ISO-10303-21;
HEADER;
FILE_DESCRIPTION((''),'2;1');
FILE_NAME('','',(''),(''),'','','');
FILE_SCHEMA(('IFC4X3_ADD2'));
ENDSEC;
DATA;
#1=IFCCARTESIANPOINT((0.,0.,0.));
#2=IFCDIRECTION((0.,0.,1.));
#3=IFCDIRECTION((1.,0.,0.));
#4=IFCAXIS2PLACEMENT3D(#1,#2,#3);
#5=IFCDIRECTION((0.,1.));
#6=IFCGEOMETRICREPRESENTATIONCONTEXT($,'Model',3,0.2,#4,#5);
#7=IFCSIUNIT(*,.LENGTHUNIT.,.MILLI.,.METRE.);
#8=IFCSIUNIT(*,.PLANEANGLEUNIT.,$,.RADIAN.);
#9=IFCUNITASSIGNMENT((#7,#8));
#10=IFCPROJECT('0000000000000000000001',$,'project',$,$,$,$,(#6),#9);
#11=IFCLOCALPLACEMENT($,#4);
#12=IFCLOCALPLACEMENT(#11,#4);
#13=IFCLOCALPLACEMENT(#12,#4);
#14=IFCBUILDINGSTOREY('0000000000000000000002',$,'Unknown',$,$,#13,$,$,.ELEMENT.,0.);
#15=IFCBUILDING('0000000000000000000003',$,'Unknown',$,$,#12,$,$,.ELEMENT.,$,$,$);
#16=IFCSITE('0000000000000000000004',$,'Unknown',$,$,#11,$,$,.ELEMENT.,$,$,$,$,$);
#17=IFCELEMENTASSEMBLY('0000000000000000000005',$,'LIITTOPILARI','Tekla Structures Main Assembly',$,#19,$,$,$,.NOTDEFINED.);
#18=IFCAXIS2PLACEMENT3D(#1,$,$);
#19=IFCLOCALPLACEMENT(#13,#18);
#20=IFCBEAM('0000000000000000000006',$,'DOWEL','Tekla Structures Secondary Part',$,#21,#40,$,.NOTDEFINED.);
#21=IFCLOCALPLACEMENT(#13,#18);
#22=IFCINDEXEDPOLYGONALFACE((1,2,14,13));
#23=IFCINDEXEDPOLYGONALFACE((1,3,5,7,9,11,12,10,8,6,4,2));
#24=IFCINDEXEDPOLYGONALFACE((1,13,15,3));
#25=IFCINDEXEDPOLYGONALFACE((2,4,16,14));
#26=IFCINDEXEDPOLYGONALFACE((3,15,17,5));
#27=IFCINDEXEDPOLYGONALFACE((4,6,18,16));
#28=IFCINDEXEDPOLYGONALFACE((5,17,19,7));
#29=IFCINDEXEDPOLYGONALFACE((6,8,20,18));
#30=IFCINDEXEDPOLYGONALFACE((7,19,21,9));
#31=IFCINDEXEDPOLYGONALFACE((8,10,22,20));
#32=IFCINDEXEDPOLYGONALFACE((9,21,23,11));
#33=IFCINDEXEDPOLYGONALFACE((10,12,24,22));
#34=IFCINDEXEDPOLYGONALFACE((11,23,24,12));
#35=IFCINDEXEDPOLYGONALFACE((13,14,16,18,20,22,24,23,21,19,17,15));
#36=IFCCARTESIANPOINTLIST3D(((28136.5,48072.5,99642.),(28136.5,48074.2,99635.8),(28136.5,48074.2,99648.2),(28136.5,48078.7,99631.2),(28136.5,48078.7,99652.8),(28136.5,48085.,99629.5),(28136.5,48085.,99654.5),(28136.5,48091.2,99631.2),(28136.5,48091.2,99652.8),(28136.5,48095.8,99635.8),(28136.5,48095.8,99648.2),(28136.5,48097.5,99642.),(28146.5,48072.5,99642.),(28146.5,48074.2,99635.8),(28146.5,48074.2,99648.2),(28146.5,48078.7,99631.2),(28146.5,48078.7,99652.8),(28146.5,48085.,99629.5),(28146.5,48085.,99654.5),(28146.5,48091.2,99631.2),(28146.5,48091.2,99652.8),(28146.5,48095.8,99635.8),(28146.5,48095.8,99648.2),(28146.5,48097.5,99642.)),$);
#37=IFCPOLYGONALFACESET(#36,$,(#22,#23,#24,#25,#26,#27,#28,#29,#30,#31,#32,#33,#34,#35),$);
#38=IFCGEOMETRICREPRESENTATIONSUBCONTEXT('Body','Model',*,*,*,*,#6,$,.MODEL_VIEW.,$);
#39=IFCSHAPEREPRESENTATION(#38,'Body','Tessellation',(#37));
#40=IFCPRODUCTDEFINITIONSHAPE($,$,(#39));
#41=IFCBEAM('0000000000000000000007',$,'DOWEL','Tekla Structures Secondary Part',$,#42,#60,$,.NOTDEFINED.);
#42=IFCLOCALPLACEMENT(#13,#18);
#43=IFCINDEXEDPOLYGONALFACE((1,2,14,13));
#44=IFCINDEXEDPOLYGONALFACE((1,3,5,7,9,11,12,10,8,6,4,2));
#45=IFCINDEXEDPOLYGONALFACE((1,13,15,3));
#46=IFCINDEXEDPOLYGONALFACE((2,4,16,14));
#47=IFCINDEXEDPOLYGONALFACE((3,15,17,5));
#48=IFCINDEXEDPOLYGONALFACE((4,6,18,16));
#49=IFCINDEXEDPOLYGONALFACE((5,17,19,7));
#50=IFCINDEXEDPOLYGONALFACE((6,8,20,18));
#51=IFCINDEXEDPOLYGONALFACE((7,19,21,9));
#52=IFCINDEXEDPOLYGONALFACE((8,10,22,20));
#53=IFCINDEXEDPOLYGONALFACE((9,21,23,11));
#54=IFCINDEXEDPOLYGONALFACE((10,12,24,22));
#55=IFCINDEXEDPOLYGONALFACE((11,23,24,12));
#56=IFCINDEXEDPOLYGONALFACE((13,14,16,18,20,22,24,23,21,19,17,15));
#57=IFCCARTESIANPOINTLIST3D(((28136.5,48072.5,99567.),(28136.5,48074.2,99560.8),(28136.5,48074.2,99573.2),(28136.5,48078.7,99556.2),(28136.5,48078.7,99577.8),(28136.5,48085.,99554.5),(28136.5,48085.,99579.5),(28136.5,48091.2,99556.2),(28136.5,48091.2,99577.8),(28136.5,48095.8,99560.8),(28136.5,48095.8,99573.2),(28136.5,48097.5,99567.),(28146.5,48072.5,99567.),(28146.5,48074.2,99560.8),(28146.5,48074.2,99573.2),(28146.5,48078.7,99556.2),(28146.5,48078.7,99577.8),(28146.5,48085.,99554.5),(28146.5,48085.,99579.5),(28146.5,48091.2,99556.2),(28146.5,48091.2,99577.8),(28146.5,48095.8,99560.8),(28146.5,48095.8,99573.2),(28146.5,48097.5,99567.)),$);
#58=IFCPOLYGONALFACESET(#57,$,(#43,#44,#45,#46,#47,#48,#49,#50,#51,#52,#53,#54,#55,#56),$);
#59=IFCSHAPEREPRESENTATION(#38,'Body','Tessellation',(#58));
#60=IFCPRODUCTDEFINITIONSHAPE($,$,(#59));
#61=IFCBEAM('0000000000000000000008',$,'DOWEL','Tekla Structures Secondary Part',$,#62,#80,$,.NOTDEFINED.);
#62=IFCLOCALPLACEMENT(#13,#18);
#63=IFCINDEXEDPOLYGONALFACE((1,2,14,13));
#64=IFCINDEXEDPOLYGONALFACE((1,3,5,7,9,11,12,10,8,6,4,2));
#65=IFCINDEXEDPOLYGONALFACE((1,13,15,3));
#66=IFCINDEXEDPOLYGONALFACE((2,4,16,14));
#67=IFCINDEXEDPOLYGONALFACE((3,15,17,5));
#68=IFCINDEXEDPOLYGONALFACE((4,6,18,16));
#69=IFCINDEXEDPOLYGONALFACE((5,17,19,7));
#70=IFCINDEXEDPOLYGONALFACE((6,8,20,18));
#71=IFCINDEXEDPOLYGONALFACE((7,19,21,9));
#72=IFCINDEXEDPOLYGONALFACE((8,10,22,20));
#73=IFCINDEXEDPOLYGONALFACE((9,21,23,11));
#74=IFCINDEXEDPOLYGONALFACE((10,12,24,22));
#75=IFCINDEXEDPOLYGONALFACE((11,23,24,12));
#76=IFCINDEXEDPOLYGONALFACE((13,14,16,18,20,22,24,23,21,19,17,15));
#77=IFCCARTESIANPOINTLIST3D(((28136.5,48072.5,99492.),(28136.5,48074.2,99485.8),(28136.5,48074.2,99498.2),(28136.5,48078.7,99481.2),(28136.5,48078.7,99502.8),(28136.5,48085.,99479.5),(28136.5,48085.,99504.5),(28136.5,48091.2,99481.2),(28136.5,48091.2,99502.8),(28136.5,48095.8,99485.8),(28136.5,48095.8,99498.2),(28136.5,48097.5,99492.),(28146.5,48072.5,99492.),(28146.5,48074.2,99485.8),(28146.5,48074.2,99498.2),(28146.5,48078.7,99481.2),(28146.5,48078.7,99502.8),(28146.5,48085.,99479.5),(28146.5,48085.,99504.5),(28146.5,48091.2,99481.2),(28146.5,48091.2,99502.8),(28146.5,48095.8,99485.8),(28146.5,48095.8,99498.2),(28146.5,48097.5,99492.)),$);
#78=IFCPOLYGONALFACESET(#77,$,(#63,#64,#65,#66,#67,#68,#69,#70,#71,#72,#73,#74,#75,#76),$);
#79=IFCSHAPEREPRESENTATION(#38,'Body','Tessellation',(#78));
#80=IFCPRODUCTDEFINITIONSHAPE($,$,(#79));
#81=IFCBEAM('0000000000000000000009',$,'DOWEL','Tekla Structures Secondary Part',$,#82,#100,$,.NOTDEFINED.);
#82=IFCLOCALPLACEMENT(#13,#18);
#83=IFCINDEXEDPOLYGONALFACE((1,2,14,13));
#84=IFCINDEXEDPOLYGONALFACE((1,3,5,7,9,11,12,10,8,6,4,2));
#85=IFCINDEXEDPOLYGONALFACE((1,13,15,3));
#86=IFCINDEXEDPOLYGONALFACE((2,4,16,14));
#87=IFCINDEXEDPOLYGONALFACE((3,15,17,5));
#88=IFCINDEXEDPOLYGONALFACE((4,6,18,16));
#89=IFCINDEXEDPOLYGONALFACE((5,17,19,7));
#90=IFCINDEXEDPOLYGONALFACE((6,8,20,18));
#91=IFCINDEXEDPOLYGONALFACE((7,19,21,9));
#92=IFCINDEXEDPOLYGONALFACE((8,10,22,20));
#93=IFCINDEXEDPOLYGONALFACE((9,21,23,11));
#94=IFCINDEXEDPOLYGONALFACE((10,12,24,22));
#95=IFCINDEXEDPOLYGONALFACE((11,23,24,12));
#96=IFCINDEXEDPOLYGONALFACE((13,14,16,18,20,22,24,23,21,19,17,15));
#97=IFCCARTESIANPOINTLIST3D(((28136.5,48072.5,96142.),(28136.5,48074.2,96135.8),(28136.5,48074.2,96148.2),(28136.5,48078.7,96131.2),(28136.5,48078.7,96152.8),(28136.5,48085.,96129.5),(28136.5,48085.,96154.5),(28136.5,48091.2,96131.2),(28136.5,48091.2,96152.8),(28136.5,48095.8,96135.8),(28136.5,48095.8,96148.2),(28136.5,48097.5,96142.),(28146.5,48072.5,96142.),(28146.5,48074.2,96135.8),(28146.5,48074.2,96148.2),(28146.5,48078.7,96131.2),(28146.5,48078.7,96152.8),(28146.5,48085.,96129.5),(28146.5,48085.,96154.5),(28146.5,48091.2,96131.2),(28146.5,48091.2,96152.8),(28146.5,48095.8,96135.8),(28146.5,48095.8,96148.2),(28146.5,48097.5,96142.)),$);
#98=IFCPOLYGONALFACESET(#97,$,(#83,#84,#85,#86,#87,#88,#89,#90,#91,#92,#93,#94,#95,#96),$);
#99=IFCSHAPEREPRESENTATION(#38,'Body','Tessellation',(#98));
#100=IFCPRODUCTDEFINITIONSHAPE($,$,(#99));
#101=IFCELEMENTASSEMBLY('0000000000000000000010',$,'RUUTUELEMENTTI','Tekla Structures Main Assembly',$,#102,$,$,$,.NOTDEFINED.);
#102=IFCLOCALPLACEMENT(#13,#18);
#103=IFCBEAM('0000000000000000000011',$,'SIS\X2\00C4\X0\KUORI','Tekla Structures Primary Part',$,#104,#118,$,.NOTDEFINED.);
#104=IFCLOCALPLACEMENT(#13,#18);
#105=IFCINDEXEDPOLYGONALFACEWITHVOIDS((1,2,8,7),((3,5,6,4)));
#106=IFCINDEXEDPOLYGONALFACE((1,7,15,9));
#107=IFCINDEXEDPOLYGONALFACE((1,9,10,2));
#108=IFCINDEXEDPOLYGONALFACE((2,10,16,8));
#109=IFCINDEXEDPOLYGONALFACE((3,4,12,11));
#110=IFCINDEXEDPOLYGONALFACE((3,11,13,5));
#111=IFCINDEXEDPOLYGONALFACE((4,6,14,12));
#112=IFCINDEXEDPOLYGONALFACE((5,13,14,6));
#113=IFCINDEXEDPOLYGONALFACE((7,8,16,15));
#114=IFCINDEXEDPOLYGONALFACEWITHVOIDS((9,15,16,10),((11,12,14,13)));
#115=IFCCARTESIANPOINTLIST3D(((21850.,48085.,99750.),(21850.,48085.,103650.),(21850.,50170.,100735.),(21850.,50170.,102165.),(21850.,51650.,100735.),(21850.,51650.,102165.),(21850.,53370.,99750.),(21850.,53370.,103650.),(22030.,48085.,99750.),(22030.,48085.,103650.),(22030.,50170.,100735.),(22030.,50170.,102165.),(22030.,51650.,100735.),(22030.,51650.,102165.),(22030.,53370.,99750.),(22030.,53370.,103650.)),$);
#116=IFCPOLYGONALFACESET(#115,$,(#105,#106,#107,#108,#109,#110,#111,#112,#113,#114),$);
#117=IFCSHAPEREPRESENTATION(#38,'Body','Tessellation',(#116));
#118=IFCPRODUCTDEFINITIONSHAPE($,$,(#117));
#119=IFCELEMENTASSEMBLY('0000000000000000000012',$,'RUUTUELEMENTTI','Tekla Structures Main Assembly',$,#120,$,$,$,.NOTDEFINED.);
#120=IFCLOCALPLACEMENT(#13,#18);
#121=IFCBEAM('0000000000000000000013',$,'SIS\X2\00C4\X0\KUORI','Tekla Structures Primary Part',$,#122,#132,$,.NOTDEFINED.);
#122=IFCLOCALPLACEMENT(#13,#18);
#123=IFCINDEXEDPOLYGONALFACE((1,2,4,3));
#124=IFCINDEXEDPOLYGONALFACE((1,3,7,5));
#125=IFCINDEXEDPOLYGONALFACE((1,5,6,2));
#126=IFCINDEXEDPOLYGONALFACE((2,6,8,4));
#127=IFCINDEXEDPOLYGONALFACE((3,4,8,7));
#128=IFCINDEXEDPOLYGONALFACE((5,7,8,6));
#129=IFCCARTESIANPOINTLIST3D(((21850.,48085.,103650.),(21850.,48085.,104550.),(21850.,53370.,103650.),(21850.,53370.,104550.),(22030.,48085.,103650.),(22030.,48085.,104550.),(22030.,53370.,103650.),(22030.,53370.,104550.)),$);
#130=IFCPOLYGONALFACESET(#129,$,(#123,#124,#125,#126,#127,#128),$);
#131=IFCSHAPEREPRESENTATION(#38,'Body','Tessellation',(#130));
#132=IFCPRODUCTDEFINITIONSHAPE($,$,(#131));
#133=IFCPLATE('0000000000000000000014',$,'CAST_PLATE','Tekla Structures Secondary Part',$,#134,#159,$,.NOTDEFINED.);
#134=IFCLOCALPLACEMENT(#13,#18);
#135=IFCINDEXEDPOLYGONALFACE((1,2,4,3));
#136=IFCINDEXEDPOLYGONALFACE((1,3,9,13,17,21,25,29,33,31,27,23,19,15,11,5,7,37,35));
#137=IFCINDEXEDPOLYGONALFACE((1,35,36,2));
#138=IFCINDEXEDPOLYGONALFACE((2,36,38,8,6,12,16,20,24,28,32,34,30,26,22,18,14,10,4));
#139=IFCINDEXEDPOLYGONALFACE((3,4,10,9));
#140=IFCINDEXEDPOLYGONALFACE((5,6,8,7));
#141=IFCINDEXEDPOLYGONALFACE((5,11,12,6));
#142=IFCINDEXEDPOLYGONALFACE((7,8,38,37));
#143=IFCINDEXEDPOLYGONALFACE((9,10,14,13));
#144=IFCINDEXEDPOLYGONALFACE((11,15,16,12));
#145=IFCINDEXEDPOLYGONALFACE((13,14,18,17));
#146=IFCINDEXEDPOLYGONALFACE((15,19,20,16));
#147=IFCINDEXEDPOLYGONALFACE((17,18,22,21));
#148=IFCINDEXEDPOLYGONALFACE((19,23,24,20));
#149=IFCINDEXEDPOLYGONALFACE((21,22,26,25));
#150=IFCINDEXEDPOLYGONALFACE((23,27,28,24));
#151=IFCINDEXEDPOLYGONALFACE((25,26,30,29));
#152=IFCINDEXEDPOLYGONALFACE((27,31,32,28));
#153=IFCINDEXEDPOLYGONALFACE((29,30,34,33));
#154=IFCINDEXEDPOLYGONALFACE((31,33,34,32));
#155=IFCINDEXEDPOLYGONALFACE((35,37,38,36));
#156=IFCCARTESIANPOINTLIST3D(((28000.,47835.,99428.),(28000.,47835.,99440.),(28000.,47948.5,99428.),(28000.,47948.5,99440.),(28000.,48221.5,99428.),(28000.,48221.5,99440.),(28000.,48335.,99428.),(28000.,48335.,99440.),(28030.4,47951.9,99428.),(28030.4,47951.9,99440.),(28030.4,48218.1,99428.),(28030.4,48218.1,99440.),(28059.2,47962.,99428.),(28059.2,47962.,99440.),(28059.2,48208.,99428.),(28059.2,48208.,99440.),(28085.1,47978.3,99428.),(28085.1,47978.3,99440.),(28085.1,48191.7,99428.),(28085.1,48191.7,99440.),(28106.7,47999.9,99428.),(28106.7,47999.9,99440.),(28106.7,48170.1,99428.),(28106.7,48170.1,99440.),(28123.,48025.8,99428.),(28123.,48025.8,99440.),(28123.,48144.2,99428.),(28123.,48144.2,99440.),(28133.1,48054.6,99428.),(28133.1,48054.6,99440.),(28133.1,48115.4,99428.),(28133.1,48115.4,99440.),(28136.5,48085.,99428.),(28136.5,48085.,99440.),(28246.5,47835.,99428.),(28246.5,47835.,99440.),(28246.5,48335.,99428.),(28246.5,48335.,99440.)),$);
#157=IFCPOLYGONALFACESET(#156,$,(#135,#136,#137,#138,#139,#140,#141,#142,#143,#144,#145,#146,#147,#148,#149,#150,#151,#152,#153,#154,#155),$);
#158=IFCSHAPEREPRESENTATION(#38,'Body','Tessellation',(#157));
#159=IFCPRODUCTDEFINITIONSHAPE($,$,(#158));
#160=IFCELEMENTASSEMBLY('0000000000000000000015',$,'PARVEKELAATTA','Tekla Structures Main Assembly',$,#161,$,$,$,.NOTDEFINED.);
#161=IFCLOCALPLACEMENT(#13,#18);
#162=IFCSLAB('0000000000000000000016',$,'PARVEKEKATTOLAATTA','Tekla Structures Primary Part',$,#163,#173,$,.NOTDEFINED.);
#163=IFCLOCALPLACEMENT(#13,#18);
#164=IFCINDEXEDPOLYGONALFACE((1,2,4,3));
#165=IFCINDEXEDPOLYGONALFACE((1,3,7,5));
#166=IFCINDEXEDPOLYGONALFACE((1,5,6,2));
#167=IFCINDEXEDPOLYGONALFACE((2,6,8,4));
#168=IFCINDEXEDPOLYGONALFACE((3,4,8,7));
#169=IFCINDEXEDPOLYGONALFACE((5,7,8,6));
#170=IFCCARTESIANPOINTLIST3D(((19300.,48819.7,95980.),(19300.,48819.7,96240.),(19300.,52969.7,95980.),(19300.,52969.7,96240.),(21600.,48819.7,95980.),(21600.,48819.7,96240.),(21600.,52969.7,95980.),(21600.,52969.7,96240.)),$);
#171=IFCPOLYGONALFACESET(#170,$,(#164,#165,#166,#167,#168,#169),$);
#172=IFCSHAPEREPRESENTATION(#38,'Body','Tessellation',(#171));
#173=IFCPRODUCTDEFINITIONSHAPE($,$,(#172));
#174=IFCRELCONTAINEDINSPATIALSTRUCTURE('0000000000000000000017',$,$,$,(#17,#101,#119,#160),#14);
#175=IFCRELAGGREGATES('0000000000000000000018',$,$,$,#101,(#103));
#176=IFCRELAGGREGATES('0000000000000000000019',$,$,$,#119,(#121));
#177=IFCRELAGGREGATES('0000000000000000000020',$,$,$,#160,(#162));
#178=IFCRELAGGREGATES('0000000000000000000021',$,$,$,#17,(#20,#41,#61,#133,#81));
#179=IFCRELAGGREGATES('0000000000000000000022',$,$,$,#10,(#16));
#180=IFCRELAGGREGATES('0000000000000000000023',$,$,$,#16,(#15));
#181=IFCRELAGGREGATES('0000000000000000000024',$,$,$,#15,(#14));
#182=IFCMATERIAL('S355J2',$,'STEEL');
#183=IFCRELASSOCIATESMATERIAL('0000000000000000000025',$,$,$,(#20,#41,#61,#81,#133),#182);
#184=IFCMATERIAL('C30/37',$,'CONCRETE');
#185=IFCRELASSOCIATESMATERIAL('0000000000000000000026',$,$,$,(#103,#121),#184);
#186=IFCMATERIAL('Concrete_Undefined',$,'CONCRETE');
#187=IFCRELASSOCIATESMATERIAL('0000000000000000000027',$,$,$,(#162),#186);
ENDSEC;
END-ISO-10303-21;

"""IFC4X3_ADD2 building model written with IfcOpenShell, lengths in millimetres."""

from ifc_helpers import new_model, si_unit, direction, frame, origin_with_axes, place, context, subcontext, project, spatial, line, indexed_curve, outline, extrude, material, element, aggregate, save


model = new_model("IFC4X3_ADD2")

# Units and contexts
model_context = context("Model", 3, precision=0.2, world=origin_with_axes(), true_north=direction((0.0, 1.0)))
body_context = subcontext(model_context, "Body", "Model", "MODEL_VIEW")
ifc_project = project(units=[si_unit("LENGTHUNIT", "METRE", prefix="MILLI"), si_unit("PLANEANGLEUNIT", "RADIAN")], contexts=[model_context])

# Site, building, storey
site_placement = place(None, origin_with_axes())
site = spatial("IfcSite", under=ifc_project, at=site_placement, Name="Unknown", CompositionType="ELEMENT")
building_placement = place(site_placement, origin_with_axes())
building = spatial("IfcBuilding", under=site, at=building_placement, Name="Unknown", CompositionType="ELEMENT")
storey_placement = place(building_placement, origin_with_axes())
storey = spatial("IfcBuildingStorey", under=building, at=storey_placement, Name="Unknown", CompositionType="ELEMENT", Elevation=0.0)

# Element assembly, beams
assembly_1_placement = place(storey_placement, frame((28000.0, 48085.0, 87950.0), z_axis=(-1.0, 0.0, 0.0), x_axis=(0.0, 0.0, 1.0)))
assembly_1 = element("IfcElementAssembly", 1, at=assembly_1_placement, inside=storey, Name="LIITTOPILARI", Description="Tekla Structures Main Assembly", PredefinedType="NOTDEFINED")
ifc_material_1 = material(Name="S355J2", Category="STEEL")
beam_1_placement = place(assembly_1_placement, frame((11692.0, 0.0, -146.5), z_axis=(0.0, 1.0, 0.0), x_axis=(0.0, 0.0, 1.0)))
beam_1 = element("IfcBeam", 2, at=beam_1_placement, material=ifc_material_1, Name="DOWEL", Description="Tekla Structures Secondary Part", PredefinedType="NOTDEFINED", context=body_context, shape_type="SolidModel", body=[
    extrude(outline(indexed_curve([(12.5, 0.0), (10.8, 6.2), (6.2, 10.8), (0.0, 12.5), (-6.2, 10.8), (-10.8, 6.2), (-12.5, 0.0), (-10.8, -6.2), (-6.2, -10.8), (0.0, -12.5), (6.2, -10.8), (10.8, -6.2)], segments=[line(1, 2, 3, 4, 5, 6, 7, 8, 9, 10, 11, 12, 1)])), frame((0.0, 0.0, 0.0), z_axis=(-1.0, 0.0, 0.0), x_axis=(0.0, 0.0, 1.0)), (0.0, 0.0, -1.0), 10.0),
])
beam_2_placement = place(assembly_1_placement, frame((11617.0, 0.0, -146.5), z_axis=(0.0, 1.0, 0.0), x_axis=(0.0, 0.0, 1.0)))
beam_2 = element("IfcBeam", 3, at=beam_2_placement, material=ifc_material_1, Name="DOWEL", Description="Tekla Structures Secondary Part", PredefinedType="NOTDEFINED", context=body_context, shape_type="SolidModel", body=[
    extrude(outline(indexed_curve([(12.5, 0.0), (10.8, 6.2), (6.2, 10.8), (0.0, 12.5), (-6.2, 10.8), (-10.8, 6.2), (-12.5, 0.0), (-10.8, -6.2), (-6.2, -10.8), (0.0, -12.5), (6.2, -10.8), (10.8, -6.2)], segments=[line(1, 2, 3, 4, 5, 6, 7, 8, 9, 10, 11, 12, 1)])), frame((0.0, 0.0, 0.0), z_axis=(-1.0, 0.0, 0.0), x_axis=(0.0, 0.0, 1.0)), (0.0, 0.0, -1.0), 10.0),
])
beam_3_placement = place(assembly_1_placement, frame((11542.0, 0.0, -146.5), z_axis=(0.0, 1.0, 0.0), x_axis=(0.0, 0.0, 1.0)))
beam_3 = element("IfcBeam", 4, at=beam_3_placement, material=ifc_material_1, Name="DOWEL", Description="Tekla Structures Secondary Part", PredefinedType="NOTDEFINED", context=body_context, shape_type="SolidModel", body=[
    extrude(outline(indexed_curve([(12.5, 0.0), (10.8, 6.2), (6.2, 10.8), (0.0, 12.5), (-6.2, 10.8), (-10.8, 6.2), (-12.5, 0.0), (-10.8, -6.2), (-6.2, -10.8), (0.0, -12.5), (6.2, -10.8), (10.8, -6.2)], segments=[line(1, 2, 3, 4, 5, 6, 7, 8, 9, 10, 11, 12, 1)])), frame((0.0, 0.0, 0.0), z_axis=(-1.0, 0.0, 0.0), x_axis=(0.0, 0.0, 1.0)), (0.0, 0.0, -1.0), 10.0),
])
beam_4_placement = place(assembly_1_placement, frame((8192.0, 0.0, -146.5), z_axis=(0.0, 1.0, 0.0), x_axis=(0.0, 0.0, 1.0)))
beam_4 = element("IfcBeam", 5, at=beam_4_placement, material=ifc_material_1, Name="DOWEL", Description="Tekla Structures Secondary Part", PredefinedType="NOTDEFINED", context=body_context, shape_type="SolidModel", body=[
    extrude(outline(indexed_curve([(12.5, 0.0), (10.8, 6.2), (6.2, 10.8), (0.0, 12.5), (-6.2, 10.8), (-10.8, 6.2), (-12.5, 0.0), (-10.8, -6.2), (-6.2, -10.8), (0.0, -12.5), (6.2, -10.8), (10.8, -6.2)], segments=[line(1, 2, 3, 4, 5, 6, 7, 8, 9, 10, 11, 12, 1)])), frame((0.0, 0.0, 0.0), z_axis=(-1.0, 0.0, 0.0), x_axis=(0.0, 0.0, 1.0)), (0.0, 0.0, -1.0), 10.0),
])

# Shared definitions
ifc_material_2 = material(Name="C30/37", Category="CONCRETE")

# Element assembly, beam, voiding feature
assembly_2_placement = place(storey_placement, frame((21940.0, 48085.0, 101700.0), z_axis=(1.0, 0.0, 0.0), x_axis=(0.0, 1.0, 0.0)))
assembly_2 = element("IfcElementAssembly", 6, at=assembly_2_placement, inside=storey, Name="RUUTUELEMENTTI", Description="Tekla Structures Main Assembly", PredefinedType="NOTDEFINED")
beam_5_placement = place(assembly_2_placement, origin_with_axes())
beam_5 = element("IfcBeam", 7, at=beam_5_placement, material=ifc_material_2, Name="SISÄKUORI", Description="Tekla Structures Primary Part", PredefinedType="NOTDEFINED", context=body_context, shape_type="SolidModel", body=[
    extrude(outline(indexed_curve([(-90.0, -1950.0), (90.0, -1950.0), (90.0, 1950.0), (-90.0, 1950.0)], segments=[line(1, 2, 3, 4, 1)])), frame((0.0, 0.0, 0.0), z_axis=(-1.0, 0.0, 0.0), x_axis=(0.0, 0.0, 1.0)), (0.0, 0.0, -1.0), 5285.0),
])
voiding_feature_1_placement = place(beam_5_placement, frame((2085.0, -965.0, 0.0), z_axis=(0.0, 0.0, -1.0), x_axis=(0.0, 1.0, 0.0)))
element("IfcVoidingFeature", 8, at=voiding_feature_1_placement, cuts=beam_5, Name="CUTPART", PredefinedType="HOLE", context=body_context, shape_type="SolidModel", body=[
    extrude(outline(indexed_curve([(0.0, 0.0), (1430.0, 0.0), (1430.0, 1480.0), (0.0, 1480.0)], segments=[line(1, 2, 3, 4, 1)])), frame((0.0, 0.0, 92.5), z_axis=(0.0, 0.0, 1.0), x_axis=(1.0, 0.0, 0.0)), (0.0, 0.0, -1.0), 185.0),
])
aggregate(assembly_2, [beam_5])

# Element assembly, beam
assembly_3_placement = place(storey_placement, frame((21940.0, 48085.0, 104100.0), z_axis=(1.0, 0.0, 0.0), x_axis=(0.0, 1.0, 0.0)))
assembly_3 = element("IfcElementAssembly", 9, at=assembly_3_placement, inside=storey, Name="RUUTUELEMENTTI", Description="Tekla Structures Main Assembly", PredefinedType="NOTDEFINED")
beam_6_placement = place(assembly_3_placement, origin_with_axes())
beam_6 = element("IfcBeam", 10, at=beam_6_placement, material=ifc_material_2, Name="SISÄKUORI", Description="Tekla Structures Primary Part", PredefinedType="NOTDEFINED", context=body_context, shape_type="SolidModel", body=[
    extrude(outline(indexed_curve([(-90.0, -450.0), (90.0, -450.0), (90.0, 450.0), (-90.0, 450.0)], segments=[line(1, 2, 3, 4, 1)])), frame((0.0, 0.0, 0.0), z_axis=(-1.0, 0.0, 0.0), x_axis=(0.0, 0.0, 1.0)), (0.0, 0.0, -1.0), 5285.0),
])
aggregate(assembly_3, [beam_6])

# Plate, voiding feature
plate_1_placement = place(assembly_1_placement, frame((11484.0, 250.0, -246.5), z_axis=(1.0, 0.0, 0.0), x_axis=(0.0, 0.0, 1.0)))
plate_1 = element("IfcPlate", 11, at=plate_1_placement, material=ifc_material_1, Name="CAST_PLATE", Description="Tekla Structures Secondary Part", PredefinedType="NOTDEFINED", context=body_context, shape_type="SolidModel", body=[
    extrude(outline(indexed_curve([(0.0, 0.0), (246.5, 0.0), (246.5, 500.0), (0.0, 500.0)], segments=[line(1, 2, 3, 4, 1)])), frame((0.0, 0.0, 6.0), z_axis=(0.0, 0.0, 1.0), x_axis=(1.0, 0.0, 0.0)), (0.0, 0.0, -1.0), 12.0),
])
voiding_feature_2_placement = place(plate_1_placement, frame((246.5, 250.0, 16.0), z_axis=(0.0, 1.0, 0.0), x_axis=(0.0, 0.0, -1.0)))
element("IfcVoidingFeature", 12, at=voiding_feature_2_placement, cuts=plate_1, Name="BEAM", PredefinedType="HOLE", context=body_context, shape_type="SolidModel", body=[
    extrude(outline(indexed_curve([(136.5, 0.0), (133.1, 30.4), (123.0, 59.2), (106.7, 85.1), (85.1, 106.7), (59.2, 123.0), (30.4, 133.1), (0.0, 136.5), (-30.4, 133.1), (-59.2, 123.0), (-85.1, 106.7), (-106.7, 85.1), (-123.0, 59.2), (-133.1, 30.4), (-136.5, 0.0), (-133.1, -30.4), (-123.0, -59.2), (-106.7, -85.1), (-85.1, -106.7), (-59.2, -123.0), (-30.4, -133.1), (0.0, -136.5), (30.4, -133.1), (59.2, -123.0), (85.1, -106.7), (106.7, -85.1), (123.0, -59.2), (133.1, -30.4)], segments=[line(1, 2, 3, 4, 5, 6, 7, 8, 9, 10, 11, 12, 13, 14, 15, 16, 17, 18, 19, 20, 21, 22, 23, 24, 25, 26, 27, 28, 1)])), frame((0.0, 0.0, 0.0), z_axis=(-1.0, 0.0, 0.0), x_axis=(0.0, 0.0, 1.0)), (0.0, 0.0, -1.0), 32.0),
])

# Element assembly, slab
assembly_4_placement = place(storey_placement, frame((19300.0, 48819.7, 96110.0), z_axis=(0.0, 0.0, 1.0), x_axis=(1.0, 0.0, 0.0)))
assembly_4 = element("IfcElementAssembly", 13, at=assembly_4_placement, inside=storey, Name="PARVEKELAATTA", Description="Tekla Structures Main Assembly", PredefinedType="NOTDEFINED")
ifc_material_3 = material(Name="Concrete_Undefined", Category="CONCRETE")
slab_placement = place(assembly_4_placement, origin_with_axes())
slab = element("IfcSlab", 14, at=slab_placement, material=ifc_material_3, Name="PARVEKEKATTOLAATTA", Description="Tekla Structures Primary Part", PredefinedType="NOTDEFINED", context=body_context, shape_type="SolidModel", body=[
    extrude(outline(indexed_curve([(0.0, 0.0), (2300.0, 0.0), (2300.0, 4150.0), (0.0, 4150.0)], segments=[line(1, 2, 3, 4, 1)])), frame((0.0, 0.0, 130.0), z_axis=(0.0, 0.0, 1.0), x_axis=(1.0, 0.0, 0.0)), (0.0, 0.0, -1.0), 260.0),
])
aggregate(assembly_4, [slab])

aggregate(assembly_1, [beam_1, beam_2, beam_3, plate_1, beam_4])

save(model, "model.ifc")
